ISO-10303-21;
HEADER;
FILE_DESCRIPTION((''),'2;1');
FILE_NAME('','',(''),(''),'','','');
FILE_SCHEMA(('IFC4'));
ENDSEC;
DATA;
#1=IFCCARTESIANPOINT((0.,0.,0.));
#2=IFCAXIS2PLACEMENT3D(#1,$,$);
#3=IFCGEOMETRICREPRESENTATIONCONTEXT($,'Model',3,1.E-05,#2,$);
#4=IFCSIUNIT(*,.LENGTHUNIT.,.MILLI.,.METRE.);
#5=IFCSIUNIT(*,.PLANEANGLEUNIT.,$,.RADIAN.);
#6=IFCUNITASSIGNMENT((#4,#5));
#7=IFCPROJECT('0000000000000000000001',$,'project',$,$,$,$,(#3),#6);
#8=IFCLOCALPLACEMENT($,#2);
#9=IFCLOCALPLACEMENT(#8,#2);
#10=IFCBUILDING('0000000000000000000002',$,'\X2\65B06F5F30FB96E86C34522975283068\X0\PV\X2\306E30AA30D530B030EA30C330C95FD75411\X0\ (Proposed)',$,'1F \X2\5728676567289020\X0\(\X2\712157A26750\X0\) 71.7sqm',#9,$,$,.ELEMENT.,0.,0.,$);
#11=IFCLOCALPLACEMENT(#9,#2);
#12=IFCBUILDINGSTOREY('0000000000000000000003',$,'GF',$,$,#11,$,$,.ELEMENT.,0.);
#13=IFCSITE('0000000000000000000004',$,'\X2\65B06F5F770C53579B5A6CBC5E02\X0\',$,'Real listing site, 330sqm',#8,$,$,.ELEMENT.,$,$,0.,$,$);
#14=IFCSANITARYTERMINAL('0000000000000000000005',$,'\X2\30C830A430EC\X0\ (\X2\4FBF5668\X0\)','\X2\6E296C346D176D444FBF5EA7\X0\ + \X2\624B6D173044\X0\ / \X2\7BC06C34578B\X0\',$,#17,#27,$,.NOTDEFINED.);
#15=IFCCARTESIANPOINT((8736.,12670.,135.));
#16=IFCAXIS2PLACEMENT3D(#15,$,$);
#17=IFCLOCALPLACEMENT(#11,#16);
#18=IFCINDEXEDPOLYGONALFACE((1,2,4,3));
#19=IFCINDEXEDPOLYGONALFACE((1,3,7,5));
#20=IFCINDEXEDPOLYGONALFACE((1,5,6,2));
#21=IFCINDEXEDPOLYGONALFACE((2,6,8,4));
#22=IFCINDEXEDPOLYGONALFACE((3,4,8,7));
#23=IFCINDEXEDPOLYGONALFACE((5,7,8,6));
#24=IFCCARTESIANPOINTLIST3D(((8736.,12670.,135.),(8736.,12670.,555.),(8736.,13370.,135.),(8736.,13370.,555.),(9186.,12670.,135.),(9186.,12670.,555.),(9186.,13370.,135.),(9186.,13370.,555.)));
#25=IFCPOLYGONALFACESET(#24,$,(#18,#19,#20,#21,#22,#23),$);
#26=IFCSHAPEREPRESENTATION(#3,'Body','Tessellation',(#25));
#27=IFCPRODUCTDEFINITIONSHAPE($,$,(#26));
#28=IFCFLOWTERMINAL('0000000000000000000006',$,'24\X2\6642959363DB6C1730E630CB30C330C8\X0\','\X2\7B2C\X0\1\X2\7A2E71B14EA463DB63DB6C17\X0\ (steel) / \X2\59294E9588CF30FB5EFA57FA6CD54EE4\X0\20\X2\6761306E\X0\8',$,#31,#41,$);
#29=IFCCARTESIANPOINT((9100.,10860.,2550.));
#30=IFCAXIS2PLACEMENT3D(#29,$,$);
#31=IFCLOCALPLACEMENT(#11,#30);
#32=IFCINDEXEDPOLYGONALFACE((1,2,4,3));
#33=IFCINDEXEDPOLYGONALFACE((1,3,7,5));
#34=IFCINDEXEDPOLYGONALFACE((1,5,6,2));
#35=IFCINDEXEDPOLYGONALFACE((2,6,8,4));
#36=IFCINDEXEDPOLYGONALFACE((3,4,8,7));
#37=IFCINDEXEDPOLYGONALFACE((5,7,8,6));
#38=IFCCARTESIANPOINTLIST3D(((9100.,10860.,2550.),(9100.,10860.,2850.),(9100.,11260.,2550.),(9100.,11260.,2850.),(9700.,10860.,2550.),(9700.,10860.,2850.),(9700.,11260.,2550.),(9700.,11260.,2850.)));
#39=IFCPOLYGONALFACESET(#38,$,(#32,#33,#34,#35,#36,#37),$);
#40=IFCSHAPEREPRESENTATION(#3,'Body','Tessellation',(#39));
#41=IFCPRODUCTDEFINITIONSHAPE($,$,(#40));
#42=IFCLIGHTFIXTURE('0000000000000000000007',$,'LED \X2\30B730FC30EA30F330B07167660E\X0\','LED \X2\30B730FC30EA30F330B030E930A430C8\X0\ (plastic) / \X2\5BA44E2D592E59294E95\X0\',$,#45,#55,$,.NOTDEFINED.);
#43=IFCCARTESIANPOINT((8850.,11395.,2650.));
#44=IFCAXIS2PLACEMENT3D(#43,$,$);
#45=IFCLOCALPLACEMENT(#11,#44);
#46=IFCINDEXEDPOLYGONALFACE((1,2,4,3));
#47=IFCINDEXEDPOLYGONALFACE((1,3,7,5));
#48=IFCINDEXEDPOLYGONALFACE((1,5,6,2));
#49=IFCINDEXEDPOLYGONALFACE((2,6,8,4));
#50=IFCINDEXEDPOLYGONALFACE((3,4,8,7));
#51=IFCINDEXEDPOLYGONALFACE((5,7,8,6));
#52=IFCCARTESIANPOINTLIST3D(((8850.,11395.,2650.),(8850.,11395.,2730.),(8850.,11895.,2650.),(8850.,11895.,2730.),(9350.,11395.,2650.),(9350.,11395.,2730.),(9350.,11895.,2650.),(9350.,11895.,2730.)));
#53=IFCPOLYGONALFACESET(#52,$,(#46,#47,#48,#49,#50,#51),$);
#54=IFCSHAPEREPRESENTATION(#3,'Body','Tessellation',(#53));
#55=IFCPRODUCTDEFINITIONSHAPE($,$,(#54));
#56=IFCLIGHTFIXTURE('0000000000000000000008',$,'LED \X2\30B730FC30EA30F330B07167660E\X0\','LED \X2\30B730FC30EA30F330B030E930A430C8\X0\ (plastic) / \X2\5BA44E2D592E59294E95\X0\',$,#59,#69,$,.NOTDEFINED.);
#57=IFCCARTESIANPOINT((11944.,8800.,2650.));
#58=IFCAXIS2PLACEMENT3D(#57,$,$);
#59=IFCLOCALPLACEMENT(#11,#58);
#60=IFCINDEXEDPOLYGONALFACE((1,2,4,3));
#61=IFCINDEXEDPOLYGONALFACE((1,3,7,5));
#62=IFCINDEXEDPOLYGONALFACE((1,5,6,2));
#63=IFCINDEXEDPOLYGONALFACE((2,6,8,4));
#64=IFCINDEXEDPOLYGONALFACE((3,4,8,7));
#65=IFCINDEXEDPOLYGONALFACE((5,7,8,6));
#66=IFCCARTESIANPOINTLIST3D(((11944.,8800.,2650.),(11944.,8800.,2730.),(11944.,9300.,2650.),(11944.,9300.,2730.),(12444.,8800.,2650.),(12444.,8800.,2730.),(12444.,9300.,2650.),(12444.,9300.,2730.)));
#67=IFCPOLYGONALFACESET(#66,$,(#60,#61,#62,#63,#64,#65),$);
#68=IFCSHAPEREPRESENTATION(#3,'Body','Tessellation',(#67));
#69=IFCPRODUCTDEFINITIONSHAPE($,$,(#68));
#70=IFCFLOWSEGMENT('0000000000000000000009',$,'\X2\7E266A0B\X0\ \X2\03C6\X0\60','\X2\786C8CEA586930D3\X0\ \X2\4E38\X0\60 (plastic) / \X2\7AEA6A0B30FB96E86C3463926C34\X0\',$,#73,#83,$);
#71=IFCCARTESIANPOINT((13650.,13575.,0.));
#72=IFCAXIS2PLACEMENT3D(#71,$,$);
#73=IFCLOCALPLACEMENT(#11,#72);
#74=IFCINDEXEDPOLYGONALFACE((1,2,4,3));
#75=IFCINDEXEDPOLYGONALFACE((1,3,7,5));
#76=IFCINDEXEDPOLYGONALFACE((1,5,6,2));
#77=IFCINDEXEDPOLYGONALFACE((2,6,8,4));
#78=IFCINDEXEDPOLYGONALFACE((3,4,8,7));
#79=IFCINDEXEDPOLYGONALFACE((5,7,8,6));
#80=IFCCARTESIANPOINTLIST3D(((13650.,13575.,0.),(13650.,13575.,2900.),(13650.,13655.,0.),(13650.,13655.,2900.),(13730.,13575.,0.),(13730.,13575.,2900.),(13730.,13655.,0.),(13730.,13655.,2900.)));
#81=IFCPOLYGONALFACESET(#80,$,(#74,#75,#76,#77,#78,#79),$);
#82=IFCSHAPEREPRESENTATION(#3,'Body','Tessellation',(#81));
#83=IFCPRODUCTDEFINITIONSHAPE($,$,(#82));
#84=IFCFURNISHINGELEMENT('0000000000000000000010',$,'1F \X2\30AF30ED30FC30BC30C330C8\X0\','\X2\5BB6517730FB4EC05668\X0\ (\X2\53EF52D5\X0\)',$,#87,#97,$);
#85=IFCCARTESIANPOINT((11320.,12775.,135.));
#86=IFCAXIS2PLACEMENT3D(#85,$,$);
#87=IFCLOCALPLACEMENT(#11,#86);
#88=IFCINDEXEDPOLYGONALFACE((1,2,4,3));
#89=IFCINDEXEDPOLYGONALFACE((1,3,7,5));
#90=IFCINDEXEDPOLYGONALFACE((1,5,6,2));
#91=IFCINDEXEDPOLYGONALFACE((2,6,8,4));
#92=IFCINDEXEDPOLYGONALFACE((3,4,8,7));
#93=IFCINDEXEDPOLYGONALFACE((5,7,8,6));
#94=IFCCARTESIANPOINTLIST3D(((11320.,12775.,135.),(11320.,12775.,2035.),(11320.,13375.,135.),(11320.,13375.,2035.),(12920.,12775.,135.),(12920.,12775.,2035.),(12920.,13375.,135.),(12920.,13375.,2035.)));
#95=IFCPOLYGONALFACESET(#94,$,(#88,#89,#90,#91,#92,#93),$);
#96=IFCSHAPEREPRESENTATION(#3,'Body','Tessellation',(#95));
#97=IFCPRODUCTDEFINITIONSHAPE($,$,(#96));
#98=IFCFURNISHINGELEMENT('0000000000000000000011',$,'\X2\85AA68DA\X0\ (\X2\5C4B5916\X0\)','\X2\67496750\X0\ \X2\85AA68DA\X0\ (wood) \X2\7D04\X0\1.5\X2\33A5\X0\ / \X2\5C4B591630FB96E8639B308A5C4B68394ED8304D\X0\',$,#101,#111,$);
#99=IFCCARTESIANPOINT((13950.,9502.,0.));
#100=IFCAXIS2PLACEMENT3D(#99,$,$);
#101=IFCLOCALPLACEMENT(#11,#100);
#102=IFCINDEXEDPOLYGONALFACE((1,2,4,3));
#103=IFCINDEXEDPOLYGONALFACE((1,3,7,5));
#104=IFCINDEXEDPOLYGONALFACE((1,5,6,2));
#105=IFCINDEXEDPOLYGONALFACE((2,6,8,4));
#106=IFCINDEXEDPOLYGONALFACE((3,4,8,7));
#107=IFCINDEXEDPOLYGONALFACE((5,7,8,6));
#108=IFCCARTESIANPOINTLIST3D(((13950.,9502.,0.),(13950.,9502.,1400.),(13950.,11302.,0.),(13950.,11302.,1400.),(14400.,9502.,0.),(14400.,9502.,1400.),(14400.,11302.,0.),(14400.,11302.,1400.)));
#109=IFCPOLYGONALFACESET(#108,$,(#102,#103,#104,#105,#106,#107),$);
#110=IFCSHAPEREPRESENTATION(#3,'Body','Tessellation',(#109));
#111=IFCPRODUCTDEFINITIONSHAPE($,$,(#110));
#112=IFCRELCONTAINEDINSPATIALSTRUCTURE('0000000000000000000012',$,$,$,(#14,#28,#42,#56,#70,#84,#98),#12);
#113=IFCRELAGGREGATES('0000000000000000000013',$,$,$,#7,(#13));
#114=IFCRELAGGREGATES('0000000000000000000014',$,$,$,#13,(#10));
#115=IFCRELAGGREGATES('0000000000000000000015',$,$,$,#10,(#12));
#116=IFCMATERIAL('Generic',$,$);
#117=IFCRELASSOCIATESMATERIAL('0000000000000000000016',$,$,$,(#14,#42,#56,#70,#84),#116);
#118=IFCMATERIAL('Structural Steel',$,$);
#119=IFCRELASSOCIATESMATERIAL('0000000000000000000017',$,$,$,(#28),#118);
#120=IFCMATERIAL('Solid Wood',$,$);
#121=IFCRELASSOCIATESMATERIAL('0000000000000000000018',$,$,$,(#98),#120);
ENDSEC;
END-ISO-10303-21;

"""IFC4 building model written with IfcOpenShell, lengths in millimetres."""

from ifc_helpers import new_model, si_unit, frame, frame_2d, origin, place, context, project, spatial, rectangle, extrude, material, element, save


model = new_model("IFC4")

# Units and contexts
model_context = context("Model", 3, precision=1e-05, world=origin())
ifc_project = project(units=[si_unit("LENGTHUNIT", "METRE", prefix="MILLI"), si_unit("PLANEANGLEUNIT", "RADIAN")], contexts=[model_context])

# Site, building, storey
site_placement = place(None, origin())
site = spatial("IfcSite", under=ifc_project, at=site_placement, Name="新潟県南魚沼市", ObjectType="Real listing site, 330sqm", CompositionType="ELEMENT", RefElevation=0.0)
building_placement = place(site_placement, origin())
building = spatial("IfcBuilding", under=site, at=building_placement, Name="新潟・雨水利用とPVのオフグリッド志向 (Proposed)", ObjectType="1F 在来木造(無垢材) 71.7sqm", CompositionType="ELEMENT", ElevationOfRefHeight=0.0, ElevationOfTerrain=0.0)
storey_placement = place(building_placement, origin())
storey = spatial("IfcBuildingStorey", under=building, at=storey_placement, Name="GF", CompositionType="ELEMENT", Elevation=0.0)

# Shared definitions
ifc_material_1 = material(Name="Solid Wood")
ifc_material_2 = material(Name="Structural Steel")

# Shared definitions
ifc_material_3 = material(Name="Generic")

# Sanitary terminal
sanitary_terminal_placement = place(storey_placement, frame((8736.0, 12670.0, 135.0)))
element("IfcSanitaryTerminal", 1, at=sanitary_terminal_placement, inside=storey, material=ifc_material_3, Name="トイレ (便器)", Description="温水洗浄便座 + 手洗い / 節水型", PredefinedType="NOTDEFINED", context=model_context, shape_type="SweptSolid", body=[
    extrude(rectangle(XDim=450.0, YDim=700.0, at=frame_2d((225.0, 350.0))), frame((8736.0, 12670.0, 135.0)), (0.0, 0.0, 1.0), 420.0),
])

# Flow terminal
flow_terminal_placement = place(storey_placement, frame((9100.0, 10860.0, 2550.0)))
element("IfcFlowTerminal", 2, at=flow_terminal_placement, inside=storey, material=ifc_material_2, Name="24時間換気ユニット", Description="第1種熱交換換気 (steel) / 天井裏・建基法令20条の8", context=model_context, shape_type="SweptSolid", body=[
    extrude(rectangle(XDim=600.0, YDim=400.0, at=frame_2d((300.0, 200.0))), frame((9100.0, 10860.0, 2550.0)), (0.0, 0.0, 1.0), 300.0),
])

# Light fixtures
light_fixture_1_placement = place(storey_placement, frame((8850.0, 11395.0, 2650.0)))
element("IfcLightFixture", 3, at=light_fixture_1_placement, inside=storey, material=ifc_material_3, Name="LED シーリング照明", Description="LED シーリングライト (plastic) / 室中央天井", PredefinedType="NOTDEFINED", context=model_context, shape_type="SweptSolid", body=[
    extrude(rectangle(XDim=500.0, YDim=500.0, at=frame_2d((250.0, 250.0))), frame((8850.0, 11395.0, 2650.0)), (0.0, 0.0, 1.0), 80.0),
])
light_fixture_2_placement = place(storey_placement, frame((11944.0, 8800.0, 2650.0)))
element("IfcLightFixture", 4, at=light_fixture_2_placement, inside=storey, material=ifc_material_3, Name="LED シーリング照明", Description="LED シーリングライト (plastic) / 室中央天井", PredefinedType="NOTDEFINED", context=model_context, shape_type="SweptSolid", body=[
    extrude(rectangle(XDim=500.0, YDim=500.0, at=frame_2d((250.0, 250.0))), frame((11944.0, 8800.0, 2650.0)), (0.0, 0.0, 1.0), 80.0),
])

# Flow segment
flow_segment_placement = place(storey_placement, frame((13650.0, 13575.0, 0.0)))
element("IfcFlowSegment", 5, at=flow_segment_placement, inside=storey, material=ifc_material_3, Name="縦樋 φ60", Description="硬質塩ビ 丸60 (plastic) / 竪樋・雨水排水", context=model_context, shape_type="SweptSolid", body=[
    extrude(rectangle(XDim=80.0, YDim=80.0, at=frame_2d((40.0, 40.0))), frame((13650.0, 13575.0, 0.0)), (0.0, 0.0, 1.0), 2900.0),
])

# Furnishing elements
furnishing_1_placement = place(storey_placement, frame((11320.0, 12775.0, 135.0)))
element("IfcFurnishingElement", 6, at=furnishing_1_placement, inside=storey, material=ifc_material_3, Name="1F クローゼット", Description="家具・什器 (可動)", context=model_context, shape_type="SweptSolid", body=[
    extrude(rectangle(XDim=1600.0, YDim=600.0, at=frame_2d((800.0, 300.0))), frame((11320.0, 12775.0, 135.0)), (0.0, 0.0, 1.0), 1900.0),
])
furnishing_2_placement = place(storey_placement, frame((13950.0, 9502.0, 0.0)))
element("IfcFurnishingElement", 7, at=furnishing_2_placement, inside=storey, material=ifc_material_1, Name="薪棚 (屋外)", Description="杉材 薪棚 (wood) 約1.5㎥ / 屋外・雨掛り屋根付き", context=model_context, shape_type="SweptSolid", body=[
    extrude(rectangle(XDim=450.0, YDim=1800.0, at=frame_2d((225.0, 900.0))), frame((13950.0, 9502.0, 0.0)), (0.0, 0.0, 1.0), 1400.0),
])

save(model, "model.ifc")
